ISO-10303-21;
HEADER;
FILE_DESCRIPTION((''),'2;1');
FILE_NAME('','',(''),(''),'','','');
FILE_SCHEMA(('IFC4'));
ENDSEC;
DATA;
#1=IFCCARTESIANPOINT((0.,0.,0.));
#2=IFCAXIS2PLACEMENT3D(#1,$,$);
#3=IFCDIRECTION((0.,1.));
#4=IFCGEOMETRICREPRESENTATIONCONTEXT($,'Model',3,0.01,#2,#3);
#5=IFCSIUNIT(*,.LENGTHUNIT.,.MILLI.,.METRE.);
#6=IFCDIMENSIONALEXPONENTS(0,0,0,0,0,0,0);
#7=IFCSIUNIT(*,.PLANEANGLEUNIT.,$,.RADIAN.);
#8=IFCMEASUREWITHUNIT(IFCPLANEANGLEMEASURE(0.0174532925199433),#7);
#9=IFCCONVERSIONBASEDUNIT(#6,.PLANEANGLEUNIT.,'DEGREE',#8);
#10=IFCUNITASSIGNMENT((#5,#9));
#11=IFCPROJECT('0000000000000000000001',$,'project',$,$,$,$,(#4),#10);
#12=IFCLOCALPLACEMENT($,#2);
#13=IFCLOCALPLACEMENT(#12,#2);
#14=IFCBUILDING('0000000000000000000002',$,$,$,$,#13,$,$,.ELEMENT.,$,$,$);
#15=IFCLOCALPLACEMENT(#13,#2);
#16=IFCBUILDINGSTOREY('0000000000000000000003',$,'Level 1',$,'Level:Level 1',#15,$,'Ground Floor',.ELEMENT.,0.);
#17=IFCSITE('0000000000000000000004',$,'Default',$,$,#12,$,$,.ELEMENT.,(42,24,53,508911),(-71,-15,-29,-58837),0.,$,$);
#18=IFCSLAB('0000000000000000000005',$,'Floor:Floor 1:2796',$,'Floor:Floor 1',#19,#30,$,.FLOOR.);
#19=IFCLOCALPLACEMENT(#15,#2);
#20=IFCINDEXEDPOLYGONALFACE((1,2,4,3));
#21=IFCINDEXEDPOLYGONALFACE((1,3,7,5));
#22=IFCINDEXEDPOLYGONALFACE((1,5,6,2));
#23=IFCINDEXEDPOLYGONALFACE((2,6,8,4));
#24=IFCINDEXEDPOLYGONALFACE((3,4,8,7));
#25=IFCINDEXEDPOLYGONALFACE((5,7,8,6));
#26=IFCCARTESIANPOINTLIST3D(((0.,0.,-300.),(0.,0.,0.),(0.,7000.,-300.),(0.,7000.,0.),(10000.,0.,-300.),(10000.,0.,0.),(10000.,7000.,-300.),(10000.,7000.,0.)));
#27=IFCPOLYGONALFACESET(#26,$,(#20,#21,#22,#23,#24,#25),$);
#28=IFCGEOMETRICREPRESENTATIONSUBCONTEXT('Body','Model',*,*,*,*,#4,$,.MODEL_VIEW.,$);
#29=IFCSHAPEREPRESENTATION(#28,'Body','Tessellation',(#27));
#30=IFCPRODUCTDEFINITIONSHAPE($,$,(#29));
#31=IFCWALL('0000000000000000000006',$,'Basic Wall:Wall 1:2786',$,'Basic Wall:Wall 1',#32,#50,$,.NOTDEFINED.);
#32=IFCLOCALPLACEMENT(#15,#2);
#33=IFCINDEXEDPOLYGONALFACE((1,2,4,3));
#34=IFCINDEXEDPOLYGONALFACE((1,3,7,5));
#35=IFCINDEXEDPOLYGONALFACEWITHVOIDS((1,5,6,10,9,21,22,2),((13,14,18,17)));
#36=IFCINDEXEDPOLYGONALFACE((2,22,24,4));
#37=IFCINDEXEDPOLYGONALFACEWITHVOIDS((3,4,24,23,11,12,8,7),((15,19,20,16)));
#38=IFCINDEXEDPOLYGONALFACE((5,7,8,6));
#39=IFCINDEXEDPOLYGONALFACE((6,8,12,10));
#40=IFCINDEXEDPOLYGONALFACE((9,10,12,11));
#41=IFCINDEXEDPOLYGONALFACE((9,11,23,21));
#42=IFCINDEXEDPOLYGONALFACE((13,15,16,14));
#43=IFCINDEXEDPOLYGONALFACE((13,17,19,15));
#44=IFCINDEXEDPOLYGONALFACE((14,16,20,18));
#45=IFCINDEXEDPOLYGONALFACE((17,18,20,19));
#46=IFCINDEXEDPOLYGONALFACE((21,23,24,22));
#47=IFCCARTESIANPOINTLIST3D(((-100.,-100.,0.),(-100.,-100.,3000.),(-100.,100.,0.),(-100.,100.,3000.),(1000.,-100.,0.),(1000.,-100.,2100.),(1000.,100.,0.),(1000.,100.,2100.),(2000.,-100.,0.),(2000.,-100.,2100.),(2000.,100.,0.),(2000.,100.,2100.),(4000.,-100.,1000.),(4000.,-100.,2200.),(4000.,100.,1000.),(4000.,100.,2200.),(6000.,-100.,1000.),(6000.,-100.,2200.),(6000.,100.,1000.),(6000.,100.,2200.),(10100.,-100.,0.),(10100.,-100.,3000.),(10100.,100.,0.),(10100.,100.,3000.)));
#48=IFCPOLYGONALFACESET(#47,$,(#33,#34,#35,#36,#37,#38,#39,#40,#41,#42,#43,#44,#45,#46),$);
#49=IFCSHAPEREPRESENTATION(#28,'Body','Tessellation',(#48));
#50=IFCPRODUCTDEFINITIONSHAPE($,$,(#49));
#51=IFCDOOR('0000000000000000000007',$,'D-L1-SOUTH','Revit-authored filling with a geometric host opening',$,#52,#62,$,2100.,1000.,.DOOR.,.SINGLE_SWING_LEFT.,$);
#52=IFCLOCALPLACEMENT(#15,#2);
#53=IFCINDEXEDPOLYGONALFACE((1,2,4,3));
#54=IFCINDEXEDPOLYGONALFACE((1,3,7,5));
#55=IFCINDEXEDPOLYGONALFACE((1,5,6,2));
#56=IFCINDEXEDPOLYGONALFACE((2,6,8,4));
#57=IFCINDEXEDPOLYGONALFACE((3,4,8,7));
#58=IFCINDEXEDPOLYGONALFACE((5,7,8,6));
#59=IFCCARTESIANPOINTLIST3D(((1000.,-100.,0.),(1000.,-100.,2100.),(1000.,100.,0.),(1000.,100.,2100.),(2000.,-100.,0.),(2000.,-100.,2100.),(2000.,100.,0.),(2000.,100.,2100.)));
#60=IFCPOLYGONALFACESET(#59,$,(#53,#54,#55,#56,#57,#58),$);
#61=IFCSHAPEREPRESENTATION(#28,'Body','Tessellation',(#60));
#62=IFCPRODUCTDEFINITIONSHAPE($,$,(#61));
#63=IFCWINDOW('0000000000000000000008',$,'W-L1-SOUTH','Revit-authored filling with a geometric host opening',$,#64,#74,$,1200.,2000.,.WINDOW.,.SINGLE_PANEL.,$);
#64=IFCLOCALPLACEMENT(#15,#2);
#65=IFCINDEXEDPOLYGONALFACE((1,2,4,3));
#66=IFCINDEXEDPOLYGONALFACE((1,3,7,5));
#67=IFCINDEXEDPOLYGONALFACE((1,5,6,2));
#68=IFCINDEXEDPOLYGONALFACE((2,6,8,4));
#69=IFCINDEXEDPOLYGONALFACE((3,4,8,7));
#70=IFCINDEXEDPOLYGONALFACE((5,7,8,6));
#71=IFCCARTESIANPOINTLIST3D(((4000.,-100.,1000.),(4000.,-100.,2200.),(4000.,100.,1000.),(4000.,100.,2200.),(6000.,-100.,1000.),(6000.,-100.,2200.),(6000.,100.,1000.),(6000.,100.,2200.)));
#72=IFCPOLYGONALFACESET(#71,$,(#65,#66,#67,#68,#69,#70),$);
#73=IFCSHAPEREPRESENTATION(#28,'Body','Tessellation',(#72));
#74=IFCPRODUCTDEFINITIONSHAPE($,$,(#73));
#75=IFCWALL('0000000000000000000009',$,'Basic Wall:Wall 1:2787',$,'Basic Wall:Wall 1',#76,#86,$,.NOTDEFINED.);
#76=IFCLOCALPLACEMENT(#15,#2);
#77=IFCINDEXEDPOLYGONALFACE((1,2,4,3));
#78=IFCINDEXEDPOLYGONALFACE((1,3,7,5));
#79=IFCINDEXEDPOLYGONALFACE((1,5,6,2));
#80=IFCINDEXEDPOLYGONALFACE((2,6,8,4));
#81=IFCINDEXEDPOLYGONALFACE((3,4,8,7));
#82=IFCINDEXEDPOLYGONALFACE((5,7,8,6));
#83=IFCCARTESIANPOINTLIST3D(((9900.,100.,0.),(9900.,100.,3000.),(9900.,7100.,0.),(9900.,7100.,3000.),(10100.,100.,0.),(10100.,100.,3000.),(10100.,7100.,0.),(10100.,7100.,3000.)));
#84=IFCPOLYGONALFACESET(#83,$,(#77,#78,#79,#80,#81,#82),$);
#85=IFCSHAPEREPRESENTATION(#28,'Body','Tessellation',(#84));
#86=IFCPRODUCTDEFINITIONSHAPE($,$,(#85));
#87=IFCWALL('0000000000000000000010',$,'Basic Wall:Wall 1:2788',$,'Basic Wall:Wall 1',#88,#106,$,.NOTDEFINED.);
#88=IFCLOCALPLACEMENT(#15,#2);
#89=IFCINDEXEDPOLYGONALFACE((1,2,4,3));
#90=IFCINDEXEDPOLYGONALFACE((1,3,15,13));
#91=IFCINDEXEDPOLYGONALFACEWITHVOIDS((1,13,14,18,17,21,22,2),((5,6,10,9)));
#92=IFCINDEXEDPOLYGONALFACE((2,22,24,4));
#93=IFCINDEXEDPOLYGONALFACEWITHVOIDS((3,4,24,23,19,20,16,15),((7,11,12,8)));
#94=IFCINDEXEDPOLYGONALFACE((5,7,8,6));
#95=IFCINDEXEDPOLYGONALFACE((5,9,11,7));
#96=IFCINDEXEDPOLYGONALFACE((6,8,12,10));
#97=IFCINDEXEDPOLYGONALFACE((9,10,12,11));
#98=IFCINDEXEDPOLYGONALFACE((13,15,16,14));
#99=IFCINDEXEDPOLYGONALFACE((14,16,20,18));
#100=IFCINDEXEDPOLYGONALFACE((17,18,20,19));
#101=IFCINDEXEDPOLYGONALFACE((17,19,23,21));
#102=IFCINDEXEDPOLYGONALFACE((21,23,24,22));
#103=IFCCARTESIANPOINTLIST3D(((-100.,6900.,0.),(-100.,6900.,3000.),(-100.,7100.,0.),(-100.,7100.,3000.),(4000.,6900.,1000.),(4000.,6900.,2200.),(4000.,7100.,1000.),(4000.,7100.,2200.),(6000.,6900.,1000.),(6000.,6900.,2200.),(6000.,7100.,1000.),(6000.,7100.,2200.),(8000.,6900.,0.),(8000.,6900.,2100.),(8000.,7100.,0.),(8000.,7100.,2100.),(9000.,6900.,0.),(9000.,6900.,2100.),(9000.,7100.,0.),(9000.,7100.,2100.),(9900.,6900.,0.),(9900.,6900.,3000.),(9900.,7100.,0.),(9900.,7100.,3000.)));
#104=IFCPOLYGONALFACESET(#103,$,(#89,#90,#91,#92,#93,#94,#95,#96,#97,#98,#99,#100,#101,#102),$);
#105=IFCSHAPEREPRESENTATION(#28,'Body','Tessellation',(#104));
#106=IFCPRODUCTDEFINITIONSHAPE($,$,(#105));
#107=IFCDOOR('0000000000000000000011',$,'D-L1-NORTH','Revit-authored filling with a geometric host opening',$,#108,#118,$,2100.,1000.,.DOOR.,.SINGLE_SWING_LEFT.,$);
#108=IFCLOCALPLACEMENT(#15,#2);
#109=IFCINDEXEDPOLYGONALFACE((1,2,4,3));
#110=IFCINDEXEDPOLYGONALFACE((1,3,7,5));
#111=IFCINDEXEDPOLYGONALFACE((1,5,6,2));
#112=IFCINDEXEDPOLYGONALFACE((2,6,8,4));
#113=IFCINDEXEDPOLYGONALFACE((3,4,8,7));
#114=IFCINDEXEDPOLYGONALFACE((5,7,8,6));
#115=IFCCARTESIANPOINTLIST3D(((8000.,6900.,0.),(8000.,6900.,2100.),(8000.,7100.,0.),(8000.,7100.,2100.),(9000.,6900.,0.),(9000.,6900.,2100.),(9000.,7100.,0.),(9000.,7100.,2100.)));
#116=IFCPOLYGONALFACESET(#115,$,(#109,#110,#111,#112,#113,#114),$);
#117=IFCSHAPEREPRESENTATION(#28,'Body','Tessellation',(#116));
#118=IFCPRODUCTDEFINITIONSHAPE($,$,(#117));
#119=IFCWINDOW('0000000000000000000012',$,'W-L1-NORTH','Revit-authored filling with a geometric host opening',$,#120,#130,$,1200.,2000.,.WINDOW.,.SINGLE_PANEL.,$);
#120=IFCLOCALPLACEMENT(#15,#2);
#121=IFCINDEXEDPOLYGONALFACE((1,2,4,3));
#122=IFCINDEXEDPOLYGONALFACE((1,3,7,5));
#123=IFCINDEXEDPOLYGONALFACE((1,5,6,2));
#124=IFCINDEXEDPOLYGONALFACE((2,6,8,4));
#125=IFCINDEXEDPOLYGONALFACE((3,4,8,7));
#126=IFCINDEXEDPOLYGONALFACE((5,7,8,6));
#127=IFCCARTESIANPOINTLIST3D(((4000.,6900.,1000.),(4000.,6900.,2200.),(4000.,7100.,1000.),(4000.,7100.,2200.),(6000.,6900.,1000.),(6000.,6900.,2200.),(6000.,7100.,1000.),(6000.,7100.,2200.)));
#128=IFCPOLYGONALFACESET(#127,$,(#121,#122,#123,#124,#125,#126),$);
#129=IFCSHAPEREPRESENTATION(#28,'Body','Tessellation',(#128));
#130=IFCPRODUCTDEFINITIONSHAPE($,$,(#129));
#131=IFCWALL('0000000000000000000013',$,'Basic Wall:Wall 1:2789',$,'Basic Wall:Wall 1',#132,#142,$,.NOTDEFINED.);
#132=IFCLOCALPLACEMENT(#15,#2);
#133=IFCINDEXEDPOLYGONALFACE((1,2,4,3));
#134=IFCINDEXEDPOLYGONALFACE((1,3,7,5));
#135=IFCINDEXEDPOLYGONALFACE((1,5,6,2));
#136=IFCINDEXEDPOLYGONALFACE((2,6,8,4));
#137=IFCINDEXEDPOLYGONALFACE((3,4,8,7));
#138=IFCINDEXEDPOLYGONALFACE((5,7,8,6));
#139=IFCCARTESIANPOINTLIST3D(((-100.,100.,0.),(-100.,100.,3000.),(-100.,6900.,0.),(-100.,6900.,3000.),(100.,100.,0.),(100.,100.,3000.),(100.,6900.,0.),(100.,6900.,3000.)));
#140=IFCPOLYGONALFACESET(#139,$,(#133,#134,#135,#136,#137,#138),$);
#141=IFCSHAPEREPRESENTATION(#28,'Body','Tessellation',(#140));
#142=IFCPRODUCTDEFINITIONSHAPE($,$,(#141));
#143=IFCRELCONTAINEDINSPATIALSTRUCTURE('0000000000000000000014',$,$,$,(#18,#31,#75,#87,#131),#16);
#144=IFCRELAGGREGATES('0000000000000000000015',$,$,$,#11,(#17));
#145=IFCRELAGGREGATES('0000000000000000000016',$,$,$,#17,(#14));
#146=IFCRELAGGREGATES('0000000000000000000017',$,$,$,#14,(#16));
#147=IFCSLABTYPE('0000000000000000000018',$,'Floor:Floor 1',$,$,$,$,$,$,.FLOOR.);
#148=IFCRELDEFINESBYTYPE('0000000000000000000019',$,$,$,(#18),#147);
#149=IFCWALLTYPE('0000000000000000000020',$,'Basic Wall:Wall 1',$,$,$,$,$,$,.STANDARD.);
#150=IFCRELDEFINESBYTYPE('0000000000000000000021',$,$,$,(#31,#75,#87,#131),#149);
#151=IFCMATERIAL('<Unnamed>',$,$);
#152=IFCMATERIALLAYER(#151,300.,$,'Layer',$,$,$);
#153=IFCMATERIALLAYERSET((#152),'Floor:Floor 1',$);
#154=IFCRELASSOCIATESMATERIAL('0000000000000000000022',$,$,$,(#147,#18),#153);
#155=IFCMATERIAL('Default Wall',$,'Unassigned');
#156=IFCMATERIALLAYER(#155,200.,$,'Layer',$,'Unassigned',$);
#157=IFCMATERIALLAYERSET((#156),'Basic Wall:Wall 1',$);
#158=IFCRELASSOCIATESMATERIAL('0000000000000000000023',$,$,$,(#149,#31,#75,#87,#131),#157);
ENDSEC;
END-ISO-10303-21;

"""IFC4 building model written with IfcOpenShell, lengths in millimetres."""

from ifc_helpers import new_model, entity, si_unit, converted_unit, direction, frame, frame_2d, origin, origin_2d, origin_2d_with_axis, place, context, subcontext, project, spatial, rectangle, extrude, material, layer, layer_set, layer_usage, type_object, element, fill, save


model = new_model("IFC4")

# Units and contexts
model_context = context("Model", 3, precision=0.01, world=origin(), true_north=direction((0.0, 1.0)))
body_context = subcontext(model_context, "Body", "Model", "MODEL_VIEW")
ifc_project = project(units=[si_unit("LENGTHUNIT", "METRE", prefix="MILLI"), converted_unit("PLANEANGLEUNIT", "DEGREE", entity("IfcPlaneAngleMeasure", 0.0174532925199433), si_unit("PLANEANGLEUNIT", "RADIAN"), dimensions=[0, 0, 0, 0, 0, 0, 0])], contexts=[model_context])

# Site, building, storey
site_placement = place(None, origin())
site = spatial("IfcSite", under=ifc_project, at=site_placement, Name="Default", CompositionType="ELEMENT", RefLatitude=(42, 24, 53, 508911), RefLongitude=(-71, -15, -29, -58837), RefElevation=0.0)
building_placement = place(site_placement, origin())
building = spatial("IfcBuilding", under=site, at=building_placement, CompositionType="ELEMENT")
storey_placement = place(building_placement, origin())
storey = spatial("IfcBuildingStorey", under=building, at=storey_placement, Name="Level 1", ObjectType="Level:Level 1", LongName="Ground Floor", CompositionType="ELEMENT", Elevation=0.0)

# Slab
ifc_material_1 = material(Name="<Unnamed>")
ifc_layer_1 = layer(ifc_material_1, 300.0, Name="Layer")
ifc_layer_set_1 = layer_set([ifc_layer_1], Name="Floor:Floor 1")
ifc_layer_usage_1 = layer_usage(ifc_layer_set_1, "AXIS3", "POSITIVE", 0.0)
slab_type = type_object("IfcSlabType", Name="Floor:Floor 1", PredefinedType="FLOOR", material=ifc_layer_set_1)
slab_placement = place(storey_placement, origin())
element("IfcSlab", 1, at=slab_placement, inside=storey, type_object=slab_type, material=ifc_layer_usage_1, Name="Floor:Floor 1:2796", ObjectType="Floor:Floor 1", PredefinedType="FLOOR", context=body_context, shape_type="SweptSolid", body=[
    extrude(rectangle(XDim=7000.0, YDim=10000.0, at=origin_2d_with_axis()), frame((5000.0, 3500.0, 0.0), z_axis=(0.0, 0.0, -1.0), x_axis=(0.0, 1.0, 0.0)), (0.0, 0.0, 1.0), 300.0),
])

# Wall, openings, door, window
ifc_material_2 = material(Name="Default Wall", Category="Unassigned")
ifc_layer_2 = layer(ifc_material_2, 200.0, Name="Layer", Category="Unassigned")
ifc_layer_set_2 = layer_set([ifc_layer_2], Name="Basic Wall:Wall 1")
ifc_layer_usage_2 = layer_usage(ifc_layer_set_2, "AXIS2", "NEGATIVE", 100.0)
wall_type = type_object("IfcWallType", Name="Basic Wall:Wall 1", PredefinedType="STANDARD", material=ifc_layer_set_2)
wall_1_placement = place(storey_placement, frame((-100.0, 0.0, 0.0)))
wall_1 = element("IfcWall", 2, at=wall_1_placement, inside=storey, type_object=wall_type, material=ifc_layer_usage_2, Name="Basic Wall:Wall 1:2786", ObjectType="Basic Wall:Wall 1", PredefinedType="NOTDEFINED", context=body_context, shape_type="SweptSolid", body=[
    extrude(rectangle(XDim=10200.0, YDim=200.0, at=frame_2d((5100.0, 0.0), x_axis=(-1.0, 0.0))), origin(), (0.0, 0.0, 1.0), 3000.0),
])
opening_1_placement = place(storey_placement, frame((1000.0, -100.0, 0.0)))
opening_1 = element("IfcOpeningElement", 3, at=opening_1_placement, cuts=wall_1, PredefinedType="OPENING", context=body_context, shape_type="SweptSolid", body=[
    extrude(rectangle(XDim=1000.0, YDim=200.0, at=origin_2d()), frame((500.0, 100.0, 0.0)), (0.0, 0.0, 1.0), 2100.0),
])
opening_2_placement = place(storey_placement, frame((4000.0, -100.0, 1000.0)))
opening_2 = element("IfcOpeningElement", 4, at=opening_2_placement, cuts=wall_1, PredefinedType="OPENING", context=body_context, shape_type="SweptSolid", body=[
    extrude(rectangle(XDim=2000.0, YDim=200.0, at=origin_2d()), frame((1000.0, 100.0, 0.0)), (0.0, 0.0, 1.0), 1200.0),
])
door_1_placement = place(storey_placement, frame((1000.0, -100.0, 0.0)))
door_1 = element("IfcDoor", 5, at=door_1_placement, Name="D-L1-SOUTH", Description="Revit-authored filling with a geometric host opening", OperationType="SINGLE_SWING_LEFT", OverallHeight=2100.0, OverallWidth=1000.0, PredefinedType="DOOR", context=body_context, shape_type="SweptSolid", body=[
    extrude(rectangle(XDim=1000.0, YDim=200.0, at=origin_2d()), frame((500.0, 100.0, 0.0)), (0.0, 0.0, 1.0), 2100.0),
])
fill(opening_1, door_1)
window_1_placement = place(storey_placement, frame((4000.0, -100.0, 1000.0)))
window_1 = element("IfcWindow", 6, at=window_1_placement, Name="W-L1-SOUTH", Description="Revit-authored filling with a geometric host opening", OverallHeight=1200.0, OverallWidth=2000.0, PartitioningType="SINGLE_PANEL", PredefinedType="WINDOW", context=body_context, shape_type="SweptSolid", body=[
    extrude(rectangle(XDim=2000.0, YDim=200.0, at=origin_2d()), frame((1000.0, 100.0, 0.0)), (0.0, 0.0, 1.0), 1200.0),
])
fill(opening_2, window_1)

# Wall
ifc_layer_usage_3 = layer_usage(ifc_layer_set_2, "AXIS2", "NEGATIVE", 100.0)
wall_2_placement = place(storey_placement, frame((10000.0, 100.0, 0.0), z_axis=(0.0, 0.0, 1.0), x_axis=(0.0, 1.0, 0.0)))
element("IfcWall", 7, at=wall_2_placement, inside=storey, type_object=wall_type, material=ifc_layer_usage_3, Name="Basic Wall:Wall 1:2787", ObjectType="Basic Wall:Wall 1", PredefinedType="NOTDEFINED", context=body_context, shape_type="SweptSolid", body=[
    extrude(rectangle(XDim=7000.0, YDim=200.0, at=frame_2d((3500.0, 0.0), x_axis=(-1.0, 0.0))), origin(), (0.0, 0.0, 1.0), 3000.0),
])

# Wall, openings, door, window
ifc_layer_usage_4 = layer_usage(ifc_layer_set_2, "AXIS2", "NEGATIVE", 100.0)
wall_3_placement = place(storey_placement, frame((9900.0, 7000.0, 0.0), z_axis=(0.0, 0.0, 1.0), x_axis=(-1.0, 0.0, 0.0)))
wall_3 = element("IfcWall", 8, at=wall_3_placement, inside=storey, type_object=wall_type, material=ifc_layer_usage_4, Name="Basic Wall:Wall 1:2788", ObjectType="Basic Wall:Wall 1", PredefinedType="NOTDEFINED", context=body_context, shape_type="SweptSolid", body=[
    extrude(rectangle(XDim=10000.0, YDim=200.0, at=frame_2d((5000.0, 0.0), x_axis=(-1.0, 0.0))), origin(), (0.0, 0.0, 1.0), 3000.0),
])
opening_3_placement = place(storey_placement, frame((8000.0, 6900.0, 0.0)))
opening_3 = element("IfcOpeningElement", 9, at=opening_3_placement, cuts=wall_3, PredefinedType="OPENING", context=body_context, shape_type="SweptSolid", body=[
    extrude(rectangle(XDim=1000.0, YDim=200.0, at=origin_2d()), frame((500.0, 100.0, 0.0)), (0.0, 0.0, 1.0), 2100.0),
])
opening_4_placement = place(storey_placement, frame((4000.0, 6900.0, 1000.0)))
opening_4 = element("IfcOpeningElement", 10, at=opening_4_placement, cuts=wall_3, PredefinedType="OPENING", context=body_context, shape_type="SweptSolid", body=[
    extrude(rectangle(XDim=2000.0, YDim=200.0, at=origin_2d()), frame((1000.0, 100.0, 0.0)), (0.0, 0.0, 1.0), 1200.0),
])
door_2_placement = place(storey_placement, frame((8000.0, 6900.0, 0.0)))
door_2 = element("IfcDoor", 11, at=door_2_placement, Name="D-L1-NORTH", Description="Revit-authored filling with a geometric host opening", OperationType="SINGLE_SWING_LEFT", OverallHeight=2100.0, OverallWidth=1000.0, PredefinedType="DOOR", context=body_context, shape_type="SweptSolid", body=[
    extrude(rectangle(XDim=1000.0, YDim=200.0, at=origin_2d()), frame((500.0, 100.0, 0.0)), (0.0, 0.0, 1.0), 2100.0),
])
fill(opening_3, door_2)
window_2_placement = place(storey_placement, frame((4000.0, 6900.0, 1000.0)))
window_2 = element("IfcWindow", 12, at=window_2_placement, Name="W-L1-NORTH", Description="Revit-authored filling with a geometric host opening", OverallHeight=1200.0, OverallWidth=2000.0, PartitioningType="SINGLE_PANEL", PredefinedType="WINDOW", context=body_context, shape_type="SweptSolid", body=[
    extrude(rectangle(XDim=2000.0, YDim=200.0, at=origin_2d()), frame((1000.0, 100.0, 0.0)), (0.0, 0.0, 1.0), 1200.0),
])
fill(opening_4, window_2)

# Wall
ifc_layer_usage_5 = layer_usage(ifc_layer_set_2, "AXIS2", "NEGATIVE", 100.0)
wall_4_placement = place(storey_placement, frame((0.0, 6900.0, 0.0), z_axis=(0.0, 0.0, 1.0), x_axis=(0.0, -1.0, 0.0)))
element("IfcWall", 13, at=wall_4_placement, inside=storey, type_object=wall_type, material=ifc_layer_usage_5, Name="Basic Wall:Wall 1:2789", ObjectType="Basic Wall:Wall 1", PredefinedType="NOTDEFINED", context=body_context, shape_type="SweptSolid", body=[
    extrude(rectangle(XDim=6800.0, YDim=200.0, at=frame_2d((3400.0, 0.0), x_axis=(-1.0, 0.0))), origin(), (0.0, 0.0, 1.0), 3000.0),
])

save(model, "model.ifc")
